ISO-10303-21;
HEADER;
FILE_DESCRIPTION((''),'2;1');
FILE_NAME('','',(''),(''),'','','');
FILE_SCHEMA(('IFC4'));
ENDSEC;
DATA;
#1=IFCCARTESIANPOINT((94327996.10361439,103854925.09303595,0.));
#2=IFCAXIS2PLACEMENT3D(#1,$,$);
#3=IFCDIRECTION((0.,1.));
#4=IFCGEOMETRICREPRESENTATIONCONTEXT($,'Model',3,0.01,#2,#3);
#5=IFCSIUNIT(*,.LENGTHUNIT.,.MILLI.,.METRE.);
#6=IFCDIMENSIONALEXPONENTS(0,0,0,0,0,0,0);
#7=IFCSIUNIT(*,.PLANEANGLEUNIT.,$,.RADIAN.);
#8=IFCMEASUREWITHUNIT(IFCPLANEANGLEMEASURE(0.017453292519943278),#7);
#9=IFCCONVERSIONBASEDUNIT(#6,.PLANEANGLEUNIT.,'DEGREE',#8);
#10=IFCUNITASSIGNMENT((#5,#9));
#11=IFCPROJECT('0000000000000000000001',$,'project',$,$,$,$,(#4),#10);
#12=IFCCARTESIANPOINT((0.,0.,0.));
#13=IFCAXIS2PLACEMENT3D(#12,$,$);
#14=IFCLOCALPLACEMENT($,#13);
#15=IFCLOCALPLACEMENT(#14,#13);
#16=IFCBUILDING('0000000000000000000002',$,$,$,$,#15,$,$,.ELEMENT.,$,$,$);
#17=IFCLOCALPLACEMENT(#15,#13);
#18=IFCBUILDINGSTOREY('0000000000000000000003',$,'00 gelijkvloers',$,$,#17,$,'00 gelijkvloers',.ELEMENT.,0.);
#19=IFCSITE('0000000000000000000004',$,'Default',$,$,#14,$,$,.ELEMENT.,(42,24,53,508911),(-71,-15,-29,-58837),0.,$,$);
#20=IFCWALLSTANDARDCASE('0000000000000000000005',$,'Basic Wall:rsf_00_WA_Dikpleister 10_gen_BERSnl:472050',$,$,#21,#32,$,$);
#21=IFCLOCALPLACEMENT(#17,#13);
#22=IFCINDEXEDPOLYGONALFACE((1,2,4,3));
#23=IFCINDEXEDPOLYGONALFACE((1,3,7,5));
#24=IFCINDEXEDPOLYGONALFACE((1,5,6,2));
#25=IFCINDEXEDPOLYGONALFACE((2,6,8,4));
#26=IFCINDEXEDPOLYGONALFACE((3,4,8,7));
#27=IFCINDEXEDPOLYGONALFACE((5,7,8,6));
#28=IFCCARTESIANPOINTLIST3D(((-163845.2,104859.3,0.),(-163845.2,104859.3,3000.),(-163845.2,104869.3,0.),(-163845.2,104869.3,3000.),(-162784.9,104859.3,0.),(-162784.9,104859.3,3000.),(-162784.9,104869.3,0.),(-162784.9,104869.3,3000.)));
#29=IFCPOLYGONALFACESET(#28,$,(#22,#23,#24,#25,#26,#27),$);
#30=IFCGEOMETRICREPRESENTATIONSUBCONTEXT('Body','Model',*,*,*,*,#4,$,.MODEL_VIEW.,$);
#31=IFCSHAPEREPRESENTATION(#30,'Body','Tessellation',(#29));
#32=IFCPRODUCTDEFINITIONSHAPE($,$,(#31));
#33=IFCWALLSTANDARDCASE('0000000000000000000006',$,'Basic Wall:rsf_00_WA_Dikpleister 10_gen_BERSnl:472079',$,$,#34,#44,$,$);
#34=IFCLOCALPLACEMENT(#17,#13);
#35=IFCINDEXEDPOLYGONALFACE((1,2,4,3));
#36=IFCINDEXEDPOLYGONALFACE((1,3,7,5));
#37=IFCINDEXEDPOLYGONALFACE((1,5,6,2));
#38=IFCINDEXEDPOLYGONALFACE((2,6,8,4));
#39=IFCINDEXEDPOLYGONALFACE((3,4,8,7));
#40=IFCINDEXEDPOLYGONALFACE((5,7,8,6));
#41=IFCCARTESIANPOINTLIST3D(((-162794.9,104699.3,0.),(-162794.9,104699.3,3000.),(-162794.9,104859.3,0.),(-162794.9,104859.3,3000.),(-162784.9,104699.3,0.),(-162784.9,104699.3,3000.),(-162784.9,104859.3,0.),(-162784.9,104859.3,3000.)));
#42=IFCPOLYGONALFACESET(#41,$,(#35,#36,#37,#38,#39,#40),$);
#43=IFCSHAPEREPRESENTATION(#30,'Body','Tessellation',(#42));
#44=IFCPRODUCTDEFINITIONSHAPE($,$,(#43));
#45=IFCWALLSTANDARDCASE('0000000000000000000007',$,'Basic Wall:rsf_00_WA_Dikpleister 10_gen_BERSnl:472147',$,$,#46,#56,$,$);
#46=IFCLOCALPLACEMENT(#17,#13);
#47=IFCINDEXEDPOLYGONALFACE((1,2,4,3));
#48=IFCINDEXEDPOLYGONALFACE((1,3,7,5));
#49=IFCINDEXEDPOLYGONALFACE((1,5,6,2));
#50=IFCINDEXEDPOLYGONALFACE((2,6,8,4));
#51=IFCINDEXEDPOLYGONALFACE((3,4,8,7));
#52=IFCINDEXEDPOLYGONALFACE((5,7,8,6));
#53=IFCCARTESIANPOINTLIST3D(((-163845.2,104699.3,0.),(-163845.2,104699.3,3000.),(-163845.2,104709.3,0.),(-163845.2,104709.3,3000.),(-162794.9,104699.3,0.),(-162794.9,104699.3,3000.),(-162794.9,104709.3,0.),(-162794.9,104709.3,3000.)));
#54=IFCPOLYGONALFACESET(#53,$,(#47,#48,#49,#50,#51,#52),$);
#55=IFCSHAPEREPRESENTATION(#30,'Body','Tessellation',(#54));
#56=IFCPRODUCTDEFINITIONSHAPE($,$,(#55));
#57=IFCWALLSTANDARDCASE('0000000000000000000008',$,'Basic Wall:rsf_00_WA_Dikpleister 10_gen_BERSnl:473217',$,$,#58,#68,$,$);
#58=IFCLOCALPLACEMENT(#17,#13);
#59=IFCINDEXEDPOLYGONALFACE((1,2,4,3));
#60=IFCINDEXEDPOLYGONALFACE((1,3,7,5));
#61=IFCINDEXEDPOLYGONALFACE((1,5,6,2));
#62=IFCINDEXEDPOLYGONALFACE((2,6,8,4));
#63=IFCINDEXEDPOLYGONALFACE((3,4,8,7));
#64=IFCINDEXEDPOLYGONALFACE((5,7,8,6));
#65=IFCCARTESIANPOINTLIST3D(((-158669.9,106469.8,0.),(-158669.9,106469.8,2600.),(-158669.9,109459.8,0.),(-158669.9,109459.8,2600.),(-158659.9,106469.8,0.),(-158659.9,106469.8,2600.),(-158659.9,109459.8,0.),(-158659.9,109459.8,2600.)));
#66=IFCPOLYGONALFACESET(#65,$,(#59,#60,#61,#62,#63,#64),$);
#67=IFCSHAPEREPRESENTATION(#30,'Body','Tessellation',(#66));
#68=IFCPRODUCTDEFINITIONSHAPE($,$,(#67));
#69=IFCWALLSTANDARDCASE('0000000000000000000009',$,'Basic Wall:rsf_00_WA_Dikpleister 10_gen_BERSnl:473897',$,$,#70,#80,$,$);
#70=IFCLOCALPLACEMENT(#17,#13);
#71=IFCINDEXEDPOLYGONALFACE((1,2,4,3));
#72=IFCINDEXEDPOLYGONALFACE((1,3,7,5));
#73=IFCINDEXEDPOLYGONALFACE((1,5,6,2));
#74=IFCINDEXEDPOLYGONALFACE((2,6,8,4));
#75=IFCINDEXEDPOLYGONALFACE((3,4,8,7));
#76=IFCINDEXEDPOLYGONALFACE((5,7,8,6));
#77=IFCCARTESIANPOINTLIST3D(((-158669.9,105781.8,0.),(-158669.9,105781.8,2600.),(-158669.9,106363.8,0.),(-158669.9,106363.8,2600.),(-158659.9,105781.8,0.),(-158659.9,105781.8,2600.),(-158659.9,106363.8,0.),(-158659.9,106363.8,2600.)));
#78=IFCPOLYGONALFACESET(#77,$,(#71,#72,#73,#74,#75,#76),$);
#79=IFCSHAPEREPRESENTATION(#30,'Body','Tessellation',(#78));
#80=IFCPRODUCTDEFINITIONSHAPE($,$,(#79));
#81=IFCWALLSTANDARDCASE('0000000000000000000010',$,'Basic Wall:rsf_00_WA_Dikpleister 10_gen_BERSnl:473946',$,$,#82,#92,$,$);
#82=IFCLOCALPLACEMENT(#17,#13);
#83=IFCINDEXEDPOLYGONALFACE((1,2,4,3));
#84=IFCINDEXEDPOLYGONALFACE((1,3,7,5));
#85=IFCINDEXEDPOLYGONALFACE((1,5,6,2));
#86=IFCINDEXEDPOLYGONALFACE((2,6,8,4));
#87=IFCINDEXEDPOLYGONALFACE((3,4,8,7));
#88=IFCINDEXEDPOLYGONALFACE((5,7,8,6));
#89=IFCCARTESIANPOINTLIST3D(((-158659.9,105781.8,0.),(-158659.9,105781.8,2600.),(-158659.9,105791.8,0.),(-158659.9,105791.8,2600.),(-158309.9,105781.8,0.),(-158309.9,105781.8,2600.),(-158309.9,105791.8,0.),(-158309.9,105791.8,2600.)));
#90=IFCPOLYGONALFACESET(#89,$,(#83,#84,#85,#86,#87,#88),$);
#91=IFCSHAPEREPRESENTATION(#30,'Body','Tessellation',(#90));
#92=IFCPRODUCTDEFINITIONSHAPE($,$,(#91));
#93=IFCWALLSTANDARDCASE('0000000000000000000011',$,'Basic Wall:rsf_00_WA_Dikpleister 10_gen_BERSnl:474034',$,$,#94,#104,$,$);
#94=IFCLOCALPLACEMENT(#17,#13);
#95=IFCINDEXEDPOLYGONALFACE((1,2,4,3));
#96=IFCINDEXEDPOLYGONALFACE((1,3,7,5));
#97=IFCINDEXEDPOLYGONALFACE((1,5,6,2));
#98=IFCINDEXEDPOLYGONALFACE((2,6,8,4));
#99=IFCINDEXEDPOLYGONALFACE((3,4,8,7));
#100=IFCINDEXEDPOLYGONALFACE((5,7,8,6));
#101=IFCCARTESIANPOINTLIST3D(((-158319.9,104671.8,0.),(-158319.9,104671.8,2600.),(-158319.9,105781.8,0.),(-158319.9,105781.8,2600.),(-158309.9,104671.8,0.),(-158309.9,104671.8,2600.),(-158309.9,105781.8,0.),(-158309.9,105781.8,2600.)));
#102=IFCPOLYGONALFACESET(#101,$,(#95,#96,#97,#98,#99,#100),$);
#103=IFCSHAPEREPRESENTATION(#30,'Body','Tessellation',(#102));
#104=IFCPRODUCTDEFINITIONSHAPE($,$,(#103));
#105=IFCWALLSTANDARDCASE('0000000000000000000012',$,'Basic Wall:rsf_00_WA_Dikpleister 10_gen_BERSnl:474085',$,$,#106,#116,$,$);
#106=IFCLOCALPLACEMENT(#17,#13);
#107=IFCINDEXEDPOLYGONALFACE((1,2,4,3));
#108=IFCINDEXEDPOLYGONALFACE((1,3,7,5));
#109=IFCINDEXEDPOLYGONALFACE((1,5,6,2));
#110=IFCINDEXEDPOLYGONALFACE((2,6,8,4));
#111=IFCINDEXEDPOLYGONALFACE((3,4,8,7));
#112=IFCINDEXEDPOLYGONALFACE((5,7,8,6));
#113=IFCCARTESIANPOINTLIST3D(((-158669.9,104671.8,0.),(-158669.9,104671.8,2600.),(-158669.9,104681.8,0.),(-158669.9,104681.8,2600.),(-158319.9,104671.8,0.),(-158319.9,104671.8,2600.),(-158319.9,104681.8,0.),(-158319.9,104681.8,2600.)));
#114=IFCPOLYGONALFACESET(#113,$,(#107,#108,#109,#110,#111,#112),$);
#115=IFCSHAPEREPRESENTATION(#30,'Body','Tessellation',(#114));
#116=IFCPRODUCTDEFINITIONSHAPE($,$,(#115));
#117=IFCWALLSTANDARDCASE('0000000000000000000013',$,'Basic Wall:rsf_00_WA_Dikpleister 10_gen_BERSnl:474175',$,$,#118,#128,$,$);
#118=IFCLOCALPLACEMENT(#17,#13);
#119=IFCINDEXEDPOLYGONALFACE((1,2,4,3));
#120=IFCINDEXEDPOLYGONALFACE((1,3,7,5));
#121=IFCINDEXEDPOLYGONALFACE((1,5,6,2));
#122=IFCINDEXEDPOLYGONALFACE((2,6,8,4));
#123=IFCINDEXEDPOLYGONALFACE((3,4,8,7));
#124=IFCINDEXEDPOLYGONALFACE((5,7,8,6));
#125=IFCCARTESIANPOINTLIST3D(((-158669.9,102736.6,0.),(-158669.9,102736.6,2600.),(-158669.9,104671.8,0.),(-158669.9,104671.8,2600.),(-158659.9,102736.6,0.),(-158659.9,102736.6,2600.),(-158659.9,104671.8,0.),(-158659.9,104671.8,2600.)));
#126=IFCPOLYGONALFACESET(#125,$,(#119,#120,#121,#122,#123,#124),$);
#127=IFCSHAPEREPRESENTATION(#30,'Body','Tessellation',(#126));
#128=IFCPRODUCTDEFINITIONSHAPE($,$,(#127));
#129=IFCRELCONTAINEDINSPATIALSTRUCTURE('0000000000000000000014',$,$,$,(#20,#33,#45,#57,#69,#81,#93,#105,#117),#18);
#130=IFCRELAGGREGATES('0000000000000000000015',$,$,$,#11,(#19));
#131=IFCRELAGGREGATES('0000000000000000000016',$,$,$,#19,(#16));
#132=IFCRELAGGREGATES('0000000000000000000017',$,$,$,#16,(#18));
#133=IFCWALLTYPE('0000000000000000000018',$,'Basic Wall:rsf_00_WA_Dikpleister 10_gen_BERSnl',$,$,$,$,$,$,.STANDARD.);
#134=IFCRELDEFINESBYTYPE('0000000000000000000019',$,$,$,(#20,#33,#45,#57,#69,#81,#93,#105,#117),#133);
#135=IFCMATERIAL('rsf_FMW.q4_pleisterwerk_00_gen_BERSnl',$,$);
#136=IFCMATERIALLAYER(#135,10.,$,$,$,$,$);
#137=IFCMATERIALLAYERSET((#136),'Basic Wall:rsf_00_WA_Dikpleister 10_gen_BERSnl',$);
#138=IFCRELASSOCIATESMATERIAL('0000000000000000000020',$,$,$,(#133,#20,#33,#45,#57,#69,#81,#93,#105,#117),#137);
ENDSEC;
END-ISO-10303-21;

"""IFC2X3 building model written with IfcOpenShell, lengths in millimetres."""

from ifc_helpers import new_model, entity, si_unit, converted_unit, direction, frame, frame_2d, origin, place, context, subcontext, project, spatial, rectangle, extrude, material, layer, layer_set, layer_usage, type_object, element, save


model = new_model("IFC2X3")

# Units and contexts
model_context = context("Model", 3, precision=0.01, world=frame((94327996.10361439, 103854925.09303595, 0.0)), true_north=direction((0.0, 1.0)))
body_context = subcontext(model_context, "Body", "Model", "MODEL_VIEW")
ifc_project = project(units=[si_unit("LENGTHUNIT", "METRE", prefix="MILLI"), converted_unit("PLANEANGLEUNIT", "DEGREE", entity("IfcPlaneAngleMeasure", 0.017453292519943278), si_unit("PLANEANGLEUNIT", "RADIAN"), dimensions=[0, 0, 0, 0, 0, 0, 0])], contexts=[model_context])

# Site, building, storey
site_placement = place(None, origin())
site = spatial("IfcSite", under=ifc_project, at=site_placement, Name="Default", CompositionType="ELEMENT", RefLatitude=(42, 24, 53, 508911), RefLongitude=(-71, -15, -29, -58837), RefElevation=0.0)
building_placement = place(site_placement, origin())
building = spatial("IfcBuilding", under=site, at=building_placement, CompositionType="ELEMENT")
storey_placement = place(building_placement, origin())
storey = spatial("IfcBuildingStorey", under=building, at=storey_placement, Name="00 gelijkvloers", LongName="00 gelijkvloers", CompositionType="ELEMENT", Elevation=0.0)

# Shared definitions
ifc_material_1 = material(Name="rsf_FMW.q4_pleisterwerk_00_gen_BERSnl")
ifc_layer_1 = layer(ifc_material_1, 10.0)
ifc_layer_set_1 = layer_set([ifc_layer_1], Name="Basic Wall:rsf_00_WA_Dikpleister 10_gen_BERSnl")
wall_type_1 = type_object("IfcWallType", Name="Basic Wall:rsf_00_WA_Dikpleister 10_gen_BERSnl", PredefinedType="STANDARD", material=ifc_layer_set_1)

# Walls
ifc_layer_usage_1 = layer_usage(ifc_layer_set_1, "AXIS2", "NEGATIVE", 5.0)
wall_1_placement = place(storey_placement, frame((-163845.2, 104864.3, 0.0)))
element("IfcWallStandardCase", 1, at=wall_1_placement, inside=storey, type_object=wall_type_1, material=ifc_layer_usage_1, Name="Basic Wall:rsf_00_WA_Dikpleister 10_gen_BERSnl:472050", context=body_context, shape_type="SweptSolid", body=[
    extrude(rectangle(XDim=1060.4, YDim=10.0, at=frame_2d((530.2, 0.0), x_axis=(-1.0, 0.0))), origin(), (0.0, 0.0, 1.0), 3000.0),
])
ifc_layer_usage_2 = layer_usage(ifc_layer_set_1, "AXIS2", "NEGATIVE", 5.0)
wall_2_placement = place(storey_placement, frame((-162789.9, 104859.3, 0.0), z_axis=(0.0, 0.0, 1.0), x_axis=(0.0, -1.0, 0.0)))
element("IfcWallStandardCase", 2, at=wall_2_placement, inside=storey, type_object=wall_type_1, material=ifc_layer_usage_2, Name="Basic Wall:rsf_00_WA_Dikpleister 10_gen_BERSnl:472079", context=body_context, shape_type="SweptSolid", body=[
    extrude(rectangle(XDim=160.0, YDim=10.0, at=frame_2d((80.0, 0.0), x_axis=(-1.0, 0.0))), origin(), (0.0, 0.0, 1.0), 3000.0),
])
ifc_layer_usage_3 = layer_usage(ifc_layer_set_1, "AXIS2", "NEGATIVE", 5.0)
wall_3_placement = place(storey_placement, frame((-162794.9, 104704.3, 0.0), z_axis=(0.0, 0.0, 1.0), x_axis=(-1.0, 0.0, 0.0)))
element("IfcWallStandardCase", 3, at=wall_3_placement, inside=storey, type_object=wall_type_1, material=ifc_layer_usage_3, Name="Basic Wall:rsf_00_WA_Dikpleister 10_gen_BERSnl:472147", context=body_context, shape_type="SweptSolid", body=[
    extrude(rectangle(XDim=1050.4, YDim=10.0, at=frame_2d((525.2, 0.0), x_axis=(-1.0, 0.0))), origin(), (0.0, 0.0, 1.0), 3000.0),
])
ifc_layer_usage_4 = layer_usage(ifc_layer_set_1, "AXIS2", "NEGATIVE", 5.0)
wall_4_placement = place(storey_placement, frame((-158664.9, 109459.8, 0.0), z_axis=(0.0, 0.0, 1.0), x_axis=(0.0, -1.0, 0.0)))
element("IfcWallStandardCase", 4, at=wall_4_placement, inside=storey, type_object=wall_type_1, material=ifc_layer_usage_4, Name="Basic Wall:rsf_00_WA_Dikpleister 10_gen_BERSnl:473217", context=body_context, shape_type="SweptSolid", body=[
    extrude(rectangle(XDim=2990.0, YDim=10.0, at=frame_2d((1495.0, 0.0), x_axis=(-1.0, 0.0))), origin(), (0.0, 0.0, 1.0), 2600.0),
])

# Walls
ifc_layer_usage_5 = layer_usage(ifc_layer_set_1, "AXIS2", "NEGATIVE", 5.0)
wall_5_placement = place(storey_placement, frame((-158664.9, 106363.8, 0.0), z_axis=(0.0, 0.0, 1.0), x_axis=(0.0, -1.0, 0.0)))
element("IfcWallStandardCase", 5, at=wall_5_placement, inside=storey, type_object=wall_type_1, material=ifc_layer_usage_5, Name="Basic Wall:rsf_00_WA_Dikpleister 10_gen_BERSnl:473897", context=body_context, shape_type="SweptSolid", body=[
    extrude(rectangle(XDim=582.0, YDim=10.0, at=frame_2d((291.0, 0.0), x_axis=(-1.0, 0.0))), origin(), (0.0, 0.0, 1.0), 2600.0),
])
ifc_layer_usage_6 = layer_usage(ifc_layer_set_1, "AXIS2", "NEGATIVE", 5.0)
wall_6_placement = place(storey_placement, frame((-158659.9, 105786.8, 0.0)))
element("IfcWallStandardCase", 6, at=wall_6_placement, inside=storey, type_object=wall_type_1, material=ifc_layer_usage_6, Name="Basic Wall:rsf_00_WA_Dikpleister 10_gen_BERSnl:473946", context=body_context, shape_type="SweptSolid", body=[
    extrude(rectangle(XDim=350.0, YDim=10.0, at=frame_2d((175.0, 0.0), x_axis=(-1.0, 0.0))), origin(), (0.0, 0.0, 1.0), 2600.0),
])
ifc_layer_usage_7 = layer_usage(ifc_layer_set_1, "AXIS2", "NEGATIVE", 5.0)
wall_7_placement = place(storey_placement, frame((-158314.9, 105781.8, 0.0), z_axis=(0.0, 0.0, 1.0), x_axis=(0.0, -1.0, 0.0)))
element("IfcWallStandardCase", 7, at=wall_7_placement, inside=storey, type_object=wall_type_1, material=ifc_layer_usage_7, Name="Basic Wall:rsf_00_WA_Dikpleister 10_gen_BERSnl:474034", context=body_context, shape_type="SweptSolid", body=[
    extrude(rectangle(XDim=1110.0, YDim=10.0, at=frame_2d((555.0, 0.0), x_axis=(-1.0, 0.0))), origin(), (0.0, 0.0, 1.0), 2600.0),
])
ifc_layer_usage_8 = layer_usage(ifc_layer_set_1, "AXIS2", "NEGATIVE", 5.0)
wall_8_placement = place(storey_placement, frame((-158319.9, 104676.8, 0.0), z_axis=(0.0, 0.0, 1.0), x_axis=(-1.0, 0.0, 0.0)))
element("IfcWallStandardCase", 8, at=wall_8_placement, inside=storey, type_object=wall_type_1, material=ifc_layer_usage_8, Name="Basic Wall:rsf_00_WA_Dikpleister 10_gen_BERSnl:474085", context=body_context, shape_type="SweptSolid", body=[
    extrude(rectangle(XDim=350.0, YDim=10.0, at=frame_2d((175.0, 0.0), x_axis=(-1.0, 0.0))), origin(), (0.0, 0.0, 1.0), 2600.0),
])
ifc_layer_usage_9 = layer_usage(ifc_layer_set_1, "AXIS2", "NEGATIVE", 5.0)
wall_9_placement = place(storey_placement, frame((-158664.9, 104671.8, 0.0), z_axis=(0.0, 0.0, 1.0), x_axis=(0.0, -1.0, 0.0)))
element("IfcWallStandardCase", 9, at=wall_9_placement, inside=storey, type_object=wall_type_1, material=ifc_layer_usage_9, Name="Basic Wall:rsf_00_WA_Dikpleister 10_gen_BERSnl:474175", context=body_context, shape_type="SweptSolid", body=[
    extrude(rectangle(XDim=1935.2, YDim=10.0, at=frame_2d((967.6, 0.0), x_axis=(-1.0, 0.0))), origin(), (0.0, 0.0, 1.0), 2600.0),
])

save(model, "model.ifc")
